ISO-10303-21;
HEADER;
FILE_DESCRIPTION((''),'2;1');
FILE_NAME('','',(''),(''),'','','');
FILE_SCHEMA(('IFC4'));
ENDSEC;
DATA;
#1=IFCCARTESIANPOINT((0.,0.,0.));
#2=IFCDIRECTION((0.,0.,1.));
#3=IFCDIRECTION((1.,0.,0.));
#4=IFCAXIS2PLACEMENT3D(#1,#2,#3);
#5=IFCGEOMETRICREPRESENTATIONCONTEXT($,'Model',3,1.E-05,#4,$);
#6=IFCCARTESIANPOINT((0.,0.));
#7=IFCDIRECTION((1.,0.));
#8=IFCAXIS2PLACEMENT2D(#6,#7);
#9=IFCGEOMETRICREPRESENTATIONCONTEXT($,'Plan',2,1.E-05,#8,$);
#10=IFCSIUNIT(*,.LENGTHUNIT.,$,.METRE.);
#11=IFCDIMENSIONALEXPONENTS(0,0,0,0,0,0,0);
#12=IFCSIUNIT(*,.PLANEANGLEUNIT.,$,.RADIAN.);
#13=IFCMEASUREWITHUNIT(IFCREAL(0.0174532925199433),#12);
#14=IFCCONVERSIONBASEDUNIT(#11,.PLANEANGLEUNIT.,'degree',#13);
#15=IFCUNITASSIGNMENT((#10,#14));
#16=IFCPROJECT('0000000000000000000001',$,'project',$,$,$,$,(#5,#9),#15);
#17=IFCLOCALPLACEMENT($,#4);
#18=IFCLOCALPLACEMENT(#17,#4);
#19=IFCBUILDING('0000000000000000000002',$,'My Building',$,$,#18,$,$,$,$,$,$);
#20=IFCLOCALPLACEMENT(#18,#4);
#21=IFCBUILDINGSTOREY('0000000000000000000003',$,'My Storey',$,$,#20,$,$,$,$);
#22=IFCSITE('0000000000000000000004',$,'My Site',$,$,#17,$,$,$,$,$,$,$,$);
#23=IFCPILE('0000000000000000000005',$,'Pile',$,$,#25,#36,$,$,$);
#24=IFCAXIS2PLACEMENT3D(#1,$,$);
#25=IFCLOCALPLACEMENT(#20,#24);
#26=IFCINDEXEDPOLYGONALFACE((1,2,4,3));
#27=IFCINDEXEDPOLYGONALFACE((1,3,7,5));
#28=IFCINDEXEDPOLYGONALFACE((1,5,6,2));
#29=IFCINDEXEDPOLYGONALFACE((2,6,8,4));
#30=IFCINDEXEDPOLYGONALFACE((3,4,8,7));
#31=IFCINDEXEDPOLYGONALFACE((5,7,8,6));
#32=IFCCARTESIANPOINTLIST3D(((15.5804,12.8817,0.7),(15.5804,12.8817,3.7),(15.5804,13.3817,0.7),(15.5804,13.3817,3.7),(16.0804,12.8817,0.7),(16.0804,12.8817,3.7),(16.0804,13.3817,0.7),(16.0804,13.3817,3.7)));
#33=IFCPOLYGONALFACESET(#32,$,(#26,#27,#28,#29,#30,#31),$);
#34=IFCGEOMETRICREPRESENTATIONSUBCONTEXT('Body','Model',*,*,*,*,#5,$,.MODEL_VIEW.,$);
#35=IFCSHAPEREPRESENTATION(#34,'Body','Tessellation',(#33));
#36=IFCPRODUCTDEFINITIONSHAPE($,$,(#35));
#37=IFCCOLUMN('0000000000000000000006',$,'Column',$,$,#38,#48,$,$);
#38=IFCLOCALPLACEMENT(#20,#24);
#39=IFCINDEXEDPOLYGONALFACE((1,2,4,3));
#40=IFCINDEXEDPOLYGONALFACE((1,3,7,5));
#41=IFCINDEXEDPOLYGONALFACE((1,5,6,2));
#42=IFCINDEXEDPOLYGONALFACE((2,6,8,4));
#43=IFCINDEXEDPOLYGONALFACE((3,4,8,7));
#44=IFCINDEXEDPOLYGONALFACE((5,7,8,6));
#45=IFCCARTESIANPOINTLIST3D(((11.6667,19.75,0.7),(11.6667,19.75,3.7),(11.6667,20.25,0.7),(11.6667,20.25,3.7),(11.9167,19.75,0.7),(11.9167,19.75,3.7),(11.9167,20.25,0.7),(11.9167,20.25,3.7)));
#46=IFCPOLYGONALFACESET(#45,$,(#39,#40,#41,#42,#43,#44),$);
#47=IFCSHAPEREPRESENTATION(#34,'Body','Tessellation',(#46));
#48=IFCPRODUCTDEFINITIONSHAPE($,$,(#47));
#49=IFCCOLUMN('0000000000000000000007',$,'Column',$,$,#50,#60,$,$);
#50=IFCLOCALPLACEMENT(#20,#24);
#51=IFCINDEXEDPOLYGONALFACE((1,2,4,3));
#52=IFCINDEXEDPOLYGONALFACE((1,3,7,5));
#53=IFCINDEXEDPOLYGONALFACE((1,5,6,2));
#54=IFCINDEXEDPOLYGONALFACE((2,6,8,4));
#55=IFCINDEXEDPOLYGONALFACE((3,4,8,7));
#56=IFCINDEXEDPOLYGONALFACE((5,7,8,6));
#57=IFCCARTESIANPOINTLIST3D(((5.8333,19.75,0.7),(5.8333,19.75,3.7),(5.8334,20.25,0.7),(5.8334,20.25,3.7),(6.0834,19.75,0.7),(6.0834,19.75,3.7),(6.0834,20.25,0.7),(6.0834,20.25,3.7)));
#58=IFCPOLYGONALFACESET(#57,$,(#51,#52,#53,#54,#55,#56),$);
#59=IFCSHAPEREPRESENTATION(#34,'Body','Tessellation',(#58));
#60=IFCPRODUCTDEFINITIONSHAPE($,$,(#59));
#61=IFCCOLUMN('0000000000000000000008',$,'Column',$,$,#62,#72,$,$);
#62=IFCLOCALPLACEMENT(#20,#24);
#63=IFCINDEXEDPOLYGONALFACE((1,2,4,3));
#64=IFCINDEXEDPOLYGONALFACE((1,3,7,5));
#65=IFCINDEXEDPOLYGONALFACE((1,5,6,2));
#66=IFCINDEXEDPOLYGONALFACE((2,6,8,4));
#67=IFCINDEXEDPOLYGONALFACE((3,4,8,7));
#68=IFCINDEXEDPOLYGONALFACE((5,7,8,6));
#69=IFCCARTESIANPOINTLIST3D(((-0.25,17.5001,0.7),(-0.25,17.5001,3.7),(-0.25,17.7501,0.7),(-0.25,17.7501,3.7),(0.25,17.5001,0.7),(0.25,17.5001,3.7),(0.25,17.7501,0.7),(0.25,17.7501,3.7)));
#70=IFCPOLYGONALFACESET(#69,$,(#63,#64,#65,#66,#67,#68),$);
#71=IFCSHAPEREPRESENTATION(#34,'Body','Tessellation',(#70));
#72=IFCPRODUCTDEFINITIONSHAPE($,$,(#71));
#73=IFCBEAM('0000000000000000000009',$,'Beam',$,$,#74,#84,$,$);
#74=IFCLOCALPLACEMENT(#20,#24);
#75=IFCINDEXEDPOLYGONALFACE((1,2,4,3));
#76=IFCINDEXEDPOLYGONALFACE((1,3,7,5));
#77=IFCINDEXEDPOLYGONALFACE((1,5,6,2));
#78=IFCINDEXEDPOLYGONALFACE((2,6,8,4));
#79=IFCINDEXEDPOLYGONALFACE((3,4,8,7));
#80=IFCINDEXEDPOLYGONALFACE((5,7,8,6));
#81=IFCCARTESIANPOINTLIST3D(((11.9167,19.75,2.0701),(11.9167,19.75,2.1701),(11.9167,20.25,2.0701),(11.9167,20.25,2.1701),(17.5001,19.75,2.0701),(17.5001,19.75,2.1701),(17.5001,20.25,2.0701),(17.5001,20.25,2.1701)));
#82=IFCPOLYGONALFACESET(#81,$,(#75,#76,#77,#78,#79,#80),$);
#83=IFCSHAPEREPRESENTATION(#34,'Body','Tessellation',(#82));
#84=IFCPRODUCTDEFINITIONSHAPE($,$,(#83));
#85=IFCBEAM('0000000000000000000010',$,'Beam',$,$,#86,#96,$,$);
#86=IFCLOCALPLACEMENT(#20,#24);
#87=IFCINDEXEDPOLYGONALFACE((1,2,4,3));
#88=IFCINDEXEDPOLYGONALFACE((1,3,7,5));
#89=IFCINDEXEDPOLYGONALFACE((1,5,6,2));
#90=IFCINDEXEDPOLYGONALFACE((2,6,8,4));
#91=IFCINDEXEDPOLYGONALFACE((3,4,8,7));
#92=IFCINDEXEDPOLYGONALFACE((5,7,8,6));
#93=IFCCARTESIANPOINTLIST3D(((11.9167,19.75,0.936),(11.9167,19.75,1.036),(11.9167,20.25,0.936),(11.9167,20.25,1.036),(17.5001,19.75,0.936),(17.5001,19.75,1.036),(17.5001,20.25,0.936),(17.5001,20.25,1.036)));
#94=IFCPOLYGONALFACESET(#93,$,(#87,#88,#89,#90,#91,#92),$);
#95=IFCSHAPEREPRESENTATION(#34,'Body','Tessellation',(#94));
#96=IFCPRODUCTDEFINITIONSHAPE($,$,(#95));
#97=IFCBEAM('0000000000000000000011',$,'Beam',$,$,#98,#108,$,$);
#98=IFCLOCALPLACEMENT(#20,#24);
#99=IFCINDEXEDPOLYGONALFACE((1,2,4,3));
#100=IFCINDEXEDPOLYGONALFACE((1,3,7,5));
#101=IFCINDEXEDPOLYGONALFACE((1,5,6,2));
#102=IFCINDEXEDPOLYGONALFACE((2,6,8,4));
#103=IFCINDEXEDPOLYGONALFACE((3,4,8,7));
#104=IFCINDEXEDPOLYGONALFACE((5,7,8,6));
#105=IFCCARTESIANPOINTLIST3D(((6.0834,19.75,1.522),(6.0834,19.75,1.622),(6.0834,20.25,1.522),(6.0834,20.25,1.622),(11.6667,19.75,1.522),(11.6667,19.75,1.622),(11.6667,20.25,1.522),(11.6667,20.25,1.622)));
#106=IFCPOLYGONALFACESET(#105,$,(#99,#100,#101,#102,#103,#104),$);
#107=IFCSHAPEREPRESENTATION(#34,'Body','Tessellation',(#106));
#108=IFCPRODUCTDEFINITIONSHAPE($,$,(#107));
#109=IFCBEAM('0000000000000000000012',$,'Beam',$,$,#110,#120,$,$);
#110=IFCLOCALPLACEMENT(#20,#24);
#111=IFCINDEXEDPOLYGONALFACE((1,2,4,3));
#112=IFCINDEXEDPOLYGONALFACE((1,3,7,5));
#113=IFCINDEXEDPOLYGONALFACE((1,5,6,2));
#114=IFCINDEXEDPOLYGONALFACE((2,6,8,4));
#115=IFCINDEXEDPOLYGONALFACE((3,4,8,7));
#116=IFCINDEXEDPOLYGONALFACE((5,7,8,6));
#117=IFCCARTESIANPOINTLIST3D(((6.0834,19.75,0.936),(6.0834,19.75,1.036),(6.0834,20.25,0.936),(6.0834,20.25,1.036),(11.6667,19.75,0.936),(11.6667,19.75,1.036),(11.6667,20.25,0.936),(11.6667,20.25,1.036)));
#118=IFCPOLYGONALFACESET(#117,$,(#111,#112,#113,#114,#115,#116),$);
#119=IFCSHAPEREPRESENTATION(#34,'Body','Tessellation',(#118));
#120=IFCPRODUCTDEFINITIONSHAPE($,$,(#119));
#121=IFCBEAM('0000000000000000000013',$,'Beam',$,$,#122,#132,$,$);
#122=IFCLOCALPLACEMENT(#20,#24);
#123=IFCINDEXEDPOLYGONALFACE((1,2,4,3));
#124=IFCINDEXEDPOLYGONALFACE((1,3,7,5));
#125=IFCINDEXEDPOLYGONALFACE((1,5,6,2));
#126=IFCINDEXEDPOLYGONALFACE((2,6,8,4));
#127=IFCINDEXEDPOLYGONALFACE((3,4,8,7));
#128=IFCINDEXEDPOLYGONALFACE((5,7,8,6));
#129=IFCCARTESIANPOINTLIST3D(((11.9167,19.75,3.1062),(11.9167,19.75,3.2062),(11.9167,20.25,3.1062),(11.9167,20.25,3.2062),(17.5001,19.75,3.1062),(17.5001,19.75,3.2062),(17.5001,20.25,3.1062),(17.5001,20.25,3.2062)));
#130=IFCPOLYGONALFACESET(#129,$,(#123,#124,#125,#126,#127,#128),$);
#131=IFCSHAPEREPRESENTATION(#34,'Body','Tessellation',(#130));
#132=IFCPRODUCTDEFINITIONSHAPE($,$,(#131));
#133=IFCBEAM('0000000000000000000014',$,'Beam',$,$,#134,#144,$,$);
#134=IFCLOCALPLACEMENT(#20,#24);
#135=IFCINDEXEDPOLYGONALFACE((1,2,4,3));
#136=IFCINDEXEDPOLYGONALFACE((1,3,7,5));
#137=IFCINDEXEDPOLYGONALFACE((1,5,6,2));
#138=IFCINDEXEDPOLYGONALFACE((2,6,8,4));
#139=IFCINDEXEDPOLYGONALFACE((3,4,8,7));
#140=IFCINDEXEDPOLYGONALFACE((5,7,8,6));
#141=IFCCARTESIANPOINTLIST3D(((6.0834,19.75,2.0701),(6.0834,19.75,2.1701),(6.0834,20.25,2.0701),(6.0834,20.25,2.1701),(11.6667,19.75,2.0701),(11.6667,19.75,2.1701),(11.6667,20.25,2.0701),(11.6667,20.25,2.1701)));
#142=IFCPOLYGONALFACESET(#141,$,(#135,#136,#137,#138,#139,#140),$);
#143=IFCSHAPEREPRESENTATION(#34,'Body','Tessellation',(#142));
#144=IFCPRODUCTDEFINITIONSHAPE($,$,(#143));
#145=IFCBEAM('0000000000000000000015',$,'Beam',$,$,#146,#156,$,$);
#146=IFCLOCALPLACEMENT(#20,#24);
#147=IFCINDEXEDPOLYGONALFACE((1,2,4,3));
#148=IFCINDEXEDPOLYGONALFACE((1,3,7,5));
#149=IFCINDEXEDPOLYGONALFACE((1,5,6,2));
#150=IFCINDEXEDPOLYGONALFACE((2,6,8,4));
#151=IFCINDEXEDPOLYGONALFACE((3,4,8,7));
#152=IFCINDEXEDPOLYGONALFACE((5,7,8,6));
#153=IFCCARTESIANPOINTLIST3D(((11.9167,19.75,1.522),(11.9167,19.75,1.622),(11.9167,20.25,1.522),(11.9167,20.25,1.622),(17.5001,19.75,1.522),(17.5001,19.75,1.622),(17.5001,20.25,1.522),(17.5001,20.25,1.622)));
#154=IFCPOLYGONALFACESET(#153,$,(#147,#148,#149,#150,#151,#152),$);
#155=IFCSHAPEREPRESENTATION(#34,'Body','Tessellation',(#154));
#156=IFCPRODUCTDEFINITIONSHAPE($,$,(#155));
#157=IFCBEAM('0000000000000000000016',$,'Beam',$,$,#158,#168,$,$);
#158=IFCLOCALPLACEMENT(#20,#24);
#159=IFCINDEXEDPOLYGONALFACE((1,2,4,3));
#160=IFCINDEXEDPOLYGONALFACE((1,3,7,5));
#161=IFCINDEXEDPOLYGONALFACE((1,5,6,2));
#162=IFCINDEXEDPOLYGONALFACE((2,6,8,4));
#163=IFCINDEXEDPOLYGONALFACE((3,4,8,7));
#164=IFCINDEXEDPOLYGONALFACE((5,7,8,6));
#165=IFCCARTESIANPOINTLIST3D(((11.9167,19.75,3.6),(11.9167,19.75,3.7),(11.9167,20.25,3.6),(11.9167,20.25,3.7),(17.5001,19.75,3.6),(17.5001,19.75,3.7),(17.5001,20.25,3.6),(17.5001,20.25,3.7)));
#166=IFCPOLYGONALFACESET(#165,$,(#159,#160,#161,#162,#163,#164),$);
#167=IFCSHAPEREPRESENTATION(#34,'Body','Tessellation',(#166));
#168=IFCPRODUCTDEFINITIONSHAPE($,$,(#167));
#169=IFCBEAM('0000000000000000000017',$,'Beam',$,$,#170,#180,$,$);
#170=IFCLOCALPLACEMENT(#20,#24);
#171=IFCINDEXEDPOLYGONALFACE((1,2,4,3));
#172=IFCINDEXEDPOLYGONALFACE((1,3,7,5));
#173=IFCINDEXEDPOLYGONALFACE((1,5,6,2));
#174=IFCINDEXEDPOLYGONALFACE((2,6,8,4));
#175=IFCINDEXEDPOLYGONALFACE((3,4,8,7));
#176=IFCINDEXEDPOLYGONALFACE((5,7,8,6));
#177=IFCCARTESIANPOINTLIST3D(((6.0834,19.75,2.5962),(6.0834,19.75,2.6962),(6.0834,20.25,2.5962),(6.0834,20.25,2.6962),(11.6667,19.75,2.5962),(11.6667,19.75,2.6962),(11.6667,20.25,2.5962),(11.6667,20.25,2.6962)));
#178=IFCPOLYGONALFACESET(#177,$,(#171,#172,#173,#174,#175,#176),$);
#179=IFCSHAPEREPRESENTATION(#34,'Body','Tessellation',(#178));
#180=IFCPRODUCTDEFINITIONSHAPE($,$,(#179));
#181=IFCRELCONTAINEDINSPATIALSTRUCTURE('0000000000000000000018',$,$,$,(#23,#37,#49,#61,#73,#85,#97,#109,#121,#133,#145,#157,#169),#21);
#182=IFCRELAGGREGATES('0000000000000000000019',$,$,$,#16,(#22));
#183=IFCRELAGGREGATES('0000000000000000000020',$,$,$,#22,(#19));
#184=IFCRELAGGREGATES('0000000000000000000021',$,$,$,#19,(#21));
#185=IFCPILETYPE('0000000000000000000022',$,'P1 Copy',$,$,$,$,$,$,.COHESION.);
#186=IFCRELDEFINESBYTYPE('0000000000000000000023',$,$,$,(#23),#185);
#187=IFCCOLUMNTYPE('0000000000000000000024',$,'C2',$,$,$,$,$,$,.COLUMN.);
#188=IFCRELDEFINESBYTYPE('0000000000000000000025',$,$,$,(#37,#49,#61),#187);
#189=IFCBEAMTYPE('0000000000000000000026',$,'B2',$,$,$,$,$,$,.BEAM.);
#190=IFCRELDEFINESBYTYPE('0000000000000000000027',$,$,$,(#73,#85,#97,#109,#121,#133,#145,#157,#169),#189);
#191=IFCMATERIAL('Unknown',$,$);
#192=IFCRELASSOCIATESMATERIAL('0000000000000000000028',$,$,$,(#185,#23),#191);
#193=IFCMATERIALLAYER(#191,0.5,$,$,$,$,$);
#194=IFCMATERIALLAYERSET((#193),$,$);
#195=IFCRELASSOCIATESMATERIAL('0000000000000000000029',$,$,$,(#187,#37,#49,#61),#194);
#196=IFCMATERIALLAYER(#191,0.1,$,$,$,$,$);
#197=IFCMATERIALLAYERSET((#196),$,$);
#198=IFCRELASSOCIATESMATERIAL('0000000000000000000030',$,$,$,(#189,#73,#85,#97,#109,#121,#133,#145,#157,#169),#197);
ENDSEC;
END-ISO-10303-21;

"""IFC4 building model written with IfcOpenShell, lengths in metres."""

from ifc_helpers import new_model, entity, si_unit, converted_unit, frame, origin_with_axes, origin_2d_with_axis, place, context, subcontext, project, spatial, line, indexed_curve, rectangle, outline, extrude, material, layer, layer_set, layer_usage, material_profile, profile_set, profile_usage, type_object, element, save


model = new_model("IFC4")

# Units and contexts
model_context = context("Model", 3, precision=1e-05, world=origin_with_axes())
plan_context = context("Plan", 2, precision=1e-05, world=origin_2d_with_axis())
body_context = subcontext(model_context, "Body", "Model", "MODEL_VIEW")
ifc_project = project(units=[si_unit("LENGTHUNIT", "METRE"), converted_unit("PLANEANGLEUNIT", "degree", entity("IfcReal", 0.0174532925199433), si_unit("PLANEANGLEUNIT", "RADIAN"), dimensions=[0, 0, 0, 0, 0, 0, 0])], contexts=[model_context, plan_context])

# Site, building, storey
site_placement = place(None, origin_with_axes())
site = spatial("IfcSite", under=ifc_project, at=site_placement, Name="My Site")
building_placement = place(site_placement, origin_with_axes())
building = spatial("IfcBuilding", under=site, at=building_placement, Name="My Building")
storey_placement = place(building_placement, origin_with_axes())
storey = spatial("IfcBuildingStorey", under=building, at=storey_placement, Name="My Storey")

# Pile
ifc_material = material(Name="Unknown")
ifc_material_profile = material_profile(ifc_material, rectangle(XDim=0.5, YDim=0.5))
ifc_profile_set = profile_set([ifc_material_profile])
ifc_profile_usage = profile_usage(ifc_profile_set, cardinal=8)
pile_type = type_object("IfcPileType", Name="P1 Copy", PredefinedType="COHESION", material=ifc_profile_set)
pile_placement = place(storey_placement, frame((15.8304, 13.3817, 0.7), z_axis=(0.0, 0.0, 1.0), x_axis=(1.0, 0.0, 0.0)))
element("IfcPile", 1, at=pile_placement, inside=storey, type_object=pile_type, material=ifc_profile_usage, Name="Pile", context=body_context, shape_type="SweptSolid", body=[
    extrude(rectangle(XDim=0.5, YDim=0.5), frame((0.0, -0.25, 0.0), z_axis=(0.0, 0.0, 1.0), x_axis=(1.0, 0.0, 0.0)), (0.0, 0.0, 1.0), 3.0),
])

# Columns
ifc_layer_1 = layer(ifc_material, 0.5)
ifc_layer_set_1 = layer_set([ifc_layer_1])
ifc_layer_usage_1 = layer_usage(ifc_layer_set_1, "AXIS2", "POSITIVE", 0.0)
column_type = type_object("IfcColumnType", Name="C2", PredefinedType="COLUMN", material=ifc_layer_set_1)
column_1_placement = place(storey_placement, frame((11.6667, 19.75, 0.7), z_axis=(0.0, 0.0, 1.0), x_axis=(1.0, -0.000008, 0.0)))
element("IfcColumn", 2, at=column_1_placement, inside=storey, type_object=column_type, material=ifc_layer_usage_1, Name="Column", context=body_context, shape_type="SweptSolid", body=[
    extrude(outline(indexed_curve([(0.0, 0.0), (0.0, 0.5), (0.25, 0.5), (0.25, 0.0)], segments=[line(1, 2, 3, 4, 1)])), origin_with_axes(), (0.0, 0.0, 1.0), 3.0),
])
ifc_layer_usage_2 = layer_usage(ifc_layer_set_1, "AXIS2", "POSITIVE", 0.0)
column_2_placement = place(storey_placement, frame((5.8333, 19.75, 0.7), z_axis=(0.0, 0.0, 1.0), x_axis=(1.0, -0.000008, 0.0)))
element("IfcColumn", 3, at=column_2_placement, inside=storey, type_object=column_type, material=ifc_layer_usage_2, Name="Column", context=body_context, shape_type="SweptSolid", body=[
    extrude(outline(indexed_curve([(0.0, 0.0), (0.0, 0.5), (0.25, 0.5), (0.25, 0.0)], segments=[line(1, 2, 3, 4, 1)])), origin_with_axes(), (0.0, 0.0, 1.0), 3.0),
])
ifc_layer_usage_3 = layer_usage(ifc_layer_set_1, "AXIS2", "POSITIVE", 0.0)
column_3_placement = place(storey_placement, frame((0.25, 17.5001, 0.7), z_axis=(0.0, 0.0, 1.0), x_axis=(0.000007, 1.0, 0.0)))
element("IfcColumn", 4, at=column_3_placement, inside=storey, type_object=column_type, material=ifc_layer_usage_3, Name="Column", context=body_context, shape_type="SweptSolid", body=[
    extrude(outline(indexed_curve([(0.0, 0.0), (0.0, 0.5), (0.25, 0.5), (0.25, 0.0)], segments=[line(1, 2, 3, 4, 1)])), origin_with_axes(), (0.0, 0.0, 1.0), 3.0),
])

# Beams
ifc_layer_2 = layer(ifc_material, 0.1)
ifc_layer_set_2 = layer_set([ifc_layer_2])
ifc_layer_usage_4 = layer_usage(ifc_layer_set_2, "AXIS3", "POSITIVE", -0.1)
beam_type_1 = type_object("IfcBeamType", Name="B2", PredefinedType="BEAM", material=ifc_layer_set_2)
beam_1_placement = place(storey_placement, frame((11.9167, 20.25, 2.1701), z_axis=(0.0, 0.0, 1.0), x_axis=(1.0, 0.0, 0.0)))
element("IfcBeam", 5, at=beam_1_placement, inside=storey, type_object=beam_type_1, material=ifc_layer_usage_4, Name="Beam", context=body_context, shape_type="SweptSolid", body=[
    extrude(outline(indexed_curve([(0.0, 0.0), (0.0, -0.5), (5.5833, -0.5), (5.5834, 0.0), (0.0, 0.0)])), frame((0.0, 0.0, -0.1), z_axis=(0.0, 0.0, 1.0), x_axis=(1.0, 0.0, 0.0)), (0.0, 0.0, 1.0), 0.1),
])
ifc_layer_usage_5 = layer_usage(ifc_layer_set_2, "AXIS3", "POSITIVE", -0.1)
beam_2_placement = place(storey_placement, frame((11.9167, 20.25, 1.036), z_axis=(0.0, 0.0, 1.0), x_axis=(1.0, 0.0, 0.0)))
element("IfcBeam", 6, at=beam_2_placement, inside=storey, type_object=beam_type_1, material=ifc_layer_usage_5, Name="Beam", context=body_context, shape_type="SweptSolid", body=[
    extrude(outline(indexed_curve([(0.0, 0.0), (0.0, -0.5), (5.5833, -0.5), (5.5834, 0.0), (0.0, 0.0)])), frame((0.0, 0.0, -0.1), z_axis=(0.0, 0.0, 1.0), x_axis=(1.0, 0.0, 0.0)), (0.0, 0.0, 1.0), 0.1),
])
ifc_layer_usage_6 = layer_usage(ifc_layer_set_2, "AXIS3", "POSITIVE", -0.1)
beam_3_placement = place(storey_placement, frame((6.0834, 20.25, 1.622), z_axis=(0.0, 0.0, 1.0), x_axis=(1.0, 0.0, 0.0)))
element("IfcBeam", 7, at=beam_3_placement, inside=storey, type_object=beam_type_1, material=ifc_layer_usage_6, Name="Beam", context=body_context, shape_type="SweptSolid", body=[
    extrude(outline(indexed_curve([(0.0, 0.0), (0.0, -0.5), (5.5833, -0.5), (5.5834, 0.0), (0.0, 0.0)])), frame((0.0, 0.0, -0.1), z_axis=(0.0, 0.0, 1.0), x_axis=(1.0, 0.0, 0.0)), (0.0, 0.0, 1.0), 0.1),
])
ifc_layer_usage_7 = layer_usage(ifc_layer_set_2, "AXIS3", "POSITIVE", -0.1)
beam_4_placement = place(storey_placement, frame((6.0834, 20.25, 1.036), z_axis=(0.0, 0.0, 1.0), x_axis=(1.0, 0.0, 0.0)))
element("IfcBeam", 8, at=beam_4_placement, inside=storey, type_object=beam_type_1, material=ifc_layer_usage_7, Name="Beam", context=body_context, shape_type="SweptSolid", body=[
    extrude(outline(indexed_curve([(0.0, 0.0), (0.0, -0.5), (5.5833, -0.5), (5.5834, 0.0), (0.0, 0.0)])), frame((0.0, 0.0, -0.1), z_axis=(0.0, 0.0, 1.0), x_axis=(1.0, 0.0, 0.0)), (0.0, 0.0, 1.0), 0.1),
])
ifc_layer_usage_8 = layer_usage(ifc_layer_set_2, "AXIS3", "POSITIVE", -0.1)
beam_5_placement = place(storey_placement, frame((11.9167, 20.25, 3.2062), z_axis=(0.0, 0.0, 1.0), x_axis=(1.0, 0.0, 0.0)))
element("IfcBeam", 9, at=beam_5_placement, inside=storey, type_object=beam_type_1, material=ifc_layer_usage_8, Name="Beam", context=body_context, shape_type="SweptSolid", body=[
    extrude(outline(indexed_curve([(0.0, 0.0), (0.0, -0.5), (5.5833, -0.5), (5.5834, 0.0), (0.0, 0.0)])), frame((0.0, 0.0, -0.1), z_axis=(0.0, 0.0, 1.0), x_axis=(1.0, 0.0, 0.0)), (0.0, 0.0, 1.0), 0.1),
])
ifc_layer_usage_9 = layer_usage(ifc_layer_set_2, "AXIS3", "POSITIVE", -0.1)
beam_6_placement = place(storey_placement, frame((6.0834, 20.25, 2.1701), z_axis=(0.0, 0.0, 1.0), x_axis=(1.0, 0.0, 0.0)))
element("IfcBeam", 10, at=beam_6_placement, inside=storey, type_object=beam_type_1, material=ifc_layer_usage_9, Name="Beam", context=body_context, shape_type="SweptSolid", body=[
    extrude(outline(indexed_curve([(0.0, 0.0), (0.0, -0.5), (5.5833, -0.5), (5.5834, 0.0), (0.0, 0.0)])), frame((0.0, 0.0, -0.1), z_axis=(0.0, 0.0, 1.0), x_axis=(1.0, 0.0, 0.0)), (0.0, 0.0, 1.0), 0.1),
])
ifc_layer_usage_10 = layer_usage(ifc_layer_set_2, "AXIS3", "POSITIVE", -0.1)
beam_7_placement = place(storey_placement, frame((11.9167, 20.25, 1.622), z_axis=(0.0, 0.0, 1.0), x_axis=(1.0, 0.0, 0.0)))
element("IfcBeam", 11, at=beam_7_placement, inside=storey, type_object=beam_type_1, material=ifc_layer_usage_10, Name="Beam", context=body_context, shape_type="SweptSolid", body=[
    extrude(outline(indexed_curve([(0.0, 0.0), (0.0, -0.5), (5.5833, -0.5), (5.5834, 0.0), (0.0, 0.0)])), frame((0.0, 0.0, -0.1), z_axis=(0.0, 0.0, 1.0), x_axis=(1.0, 0.0, 0.0)), (0.0, 0.0, 1.0), 0.1),
])
ifc_layer_usage_11 = layer_usage(ifc_layer_set_2, "AXIS3", "POSITIVE", -0.1)
beam_8_placement = place(storey_placement, frame((11.9167, 20.25, 3.7), z_axis=(0.0, 0.0, 1.0), x_axis=(1.0, 0.0, 0.0)))
element("IfcBeam", 12, at=beam_8_placement, inside=storey, type_object=beam_type_1, material=ifc_layer_usage_11, Name="Beam", context=body_context, shape_type="SweptSolid", body=[
    extrude(outline(indexed_curve([(0.0, 0.0), (0.0, -0.5), (5.5833, -0.5), (5.5834, 0.0), (0.0, 0.0)])), frame((0.0, 0.0, -0.1), z_axis=(0.0, 0.0, 1.0), x_axis=(1.0, 0.0, 0.0)), (0.0, 0.0, 1.0), 0.1),
])
ifc_layer_usage_12 = layer_usage(ifc_layer_set_2, "AXIS3", "POSITIVE", -0.1)
beam_9_placement = place(storey_placement, frame((6.0834, 20.25, 2.6962), z_axis=(0.0, 0.0, 1.0), x_axis=(1.0, 0.0, 0.0)))
element("IfcBeam", 13, at=beam_9_placement, inside=storey, type_object=beam_type_1, material=ifc_layer_usage_12, Name="Beam", context=body_context, shape_type="SweptSolid", body=[
    extrude(outline(indexed_curve([(0.0, 0.0), (0.0, -0.5), (5.5833, -0.5), (5.5834, 0.0), (0.0, 0.0)])), frame((0.0, 0.0, -0.1), z_axis=(0.0, 0.0, 1.0), x_axis=(1.0, 0.0, 0.0)), (0.0, 0.0, 1.0), 0.1),
])

save(model, "model.ifc")
